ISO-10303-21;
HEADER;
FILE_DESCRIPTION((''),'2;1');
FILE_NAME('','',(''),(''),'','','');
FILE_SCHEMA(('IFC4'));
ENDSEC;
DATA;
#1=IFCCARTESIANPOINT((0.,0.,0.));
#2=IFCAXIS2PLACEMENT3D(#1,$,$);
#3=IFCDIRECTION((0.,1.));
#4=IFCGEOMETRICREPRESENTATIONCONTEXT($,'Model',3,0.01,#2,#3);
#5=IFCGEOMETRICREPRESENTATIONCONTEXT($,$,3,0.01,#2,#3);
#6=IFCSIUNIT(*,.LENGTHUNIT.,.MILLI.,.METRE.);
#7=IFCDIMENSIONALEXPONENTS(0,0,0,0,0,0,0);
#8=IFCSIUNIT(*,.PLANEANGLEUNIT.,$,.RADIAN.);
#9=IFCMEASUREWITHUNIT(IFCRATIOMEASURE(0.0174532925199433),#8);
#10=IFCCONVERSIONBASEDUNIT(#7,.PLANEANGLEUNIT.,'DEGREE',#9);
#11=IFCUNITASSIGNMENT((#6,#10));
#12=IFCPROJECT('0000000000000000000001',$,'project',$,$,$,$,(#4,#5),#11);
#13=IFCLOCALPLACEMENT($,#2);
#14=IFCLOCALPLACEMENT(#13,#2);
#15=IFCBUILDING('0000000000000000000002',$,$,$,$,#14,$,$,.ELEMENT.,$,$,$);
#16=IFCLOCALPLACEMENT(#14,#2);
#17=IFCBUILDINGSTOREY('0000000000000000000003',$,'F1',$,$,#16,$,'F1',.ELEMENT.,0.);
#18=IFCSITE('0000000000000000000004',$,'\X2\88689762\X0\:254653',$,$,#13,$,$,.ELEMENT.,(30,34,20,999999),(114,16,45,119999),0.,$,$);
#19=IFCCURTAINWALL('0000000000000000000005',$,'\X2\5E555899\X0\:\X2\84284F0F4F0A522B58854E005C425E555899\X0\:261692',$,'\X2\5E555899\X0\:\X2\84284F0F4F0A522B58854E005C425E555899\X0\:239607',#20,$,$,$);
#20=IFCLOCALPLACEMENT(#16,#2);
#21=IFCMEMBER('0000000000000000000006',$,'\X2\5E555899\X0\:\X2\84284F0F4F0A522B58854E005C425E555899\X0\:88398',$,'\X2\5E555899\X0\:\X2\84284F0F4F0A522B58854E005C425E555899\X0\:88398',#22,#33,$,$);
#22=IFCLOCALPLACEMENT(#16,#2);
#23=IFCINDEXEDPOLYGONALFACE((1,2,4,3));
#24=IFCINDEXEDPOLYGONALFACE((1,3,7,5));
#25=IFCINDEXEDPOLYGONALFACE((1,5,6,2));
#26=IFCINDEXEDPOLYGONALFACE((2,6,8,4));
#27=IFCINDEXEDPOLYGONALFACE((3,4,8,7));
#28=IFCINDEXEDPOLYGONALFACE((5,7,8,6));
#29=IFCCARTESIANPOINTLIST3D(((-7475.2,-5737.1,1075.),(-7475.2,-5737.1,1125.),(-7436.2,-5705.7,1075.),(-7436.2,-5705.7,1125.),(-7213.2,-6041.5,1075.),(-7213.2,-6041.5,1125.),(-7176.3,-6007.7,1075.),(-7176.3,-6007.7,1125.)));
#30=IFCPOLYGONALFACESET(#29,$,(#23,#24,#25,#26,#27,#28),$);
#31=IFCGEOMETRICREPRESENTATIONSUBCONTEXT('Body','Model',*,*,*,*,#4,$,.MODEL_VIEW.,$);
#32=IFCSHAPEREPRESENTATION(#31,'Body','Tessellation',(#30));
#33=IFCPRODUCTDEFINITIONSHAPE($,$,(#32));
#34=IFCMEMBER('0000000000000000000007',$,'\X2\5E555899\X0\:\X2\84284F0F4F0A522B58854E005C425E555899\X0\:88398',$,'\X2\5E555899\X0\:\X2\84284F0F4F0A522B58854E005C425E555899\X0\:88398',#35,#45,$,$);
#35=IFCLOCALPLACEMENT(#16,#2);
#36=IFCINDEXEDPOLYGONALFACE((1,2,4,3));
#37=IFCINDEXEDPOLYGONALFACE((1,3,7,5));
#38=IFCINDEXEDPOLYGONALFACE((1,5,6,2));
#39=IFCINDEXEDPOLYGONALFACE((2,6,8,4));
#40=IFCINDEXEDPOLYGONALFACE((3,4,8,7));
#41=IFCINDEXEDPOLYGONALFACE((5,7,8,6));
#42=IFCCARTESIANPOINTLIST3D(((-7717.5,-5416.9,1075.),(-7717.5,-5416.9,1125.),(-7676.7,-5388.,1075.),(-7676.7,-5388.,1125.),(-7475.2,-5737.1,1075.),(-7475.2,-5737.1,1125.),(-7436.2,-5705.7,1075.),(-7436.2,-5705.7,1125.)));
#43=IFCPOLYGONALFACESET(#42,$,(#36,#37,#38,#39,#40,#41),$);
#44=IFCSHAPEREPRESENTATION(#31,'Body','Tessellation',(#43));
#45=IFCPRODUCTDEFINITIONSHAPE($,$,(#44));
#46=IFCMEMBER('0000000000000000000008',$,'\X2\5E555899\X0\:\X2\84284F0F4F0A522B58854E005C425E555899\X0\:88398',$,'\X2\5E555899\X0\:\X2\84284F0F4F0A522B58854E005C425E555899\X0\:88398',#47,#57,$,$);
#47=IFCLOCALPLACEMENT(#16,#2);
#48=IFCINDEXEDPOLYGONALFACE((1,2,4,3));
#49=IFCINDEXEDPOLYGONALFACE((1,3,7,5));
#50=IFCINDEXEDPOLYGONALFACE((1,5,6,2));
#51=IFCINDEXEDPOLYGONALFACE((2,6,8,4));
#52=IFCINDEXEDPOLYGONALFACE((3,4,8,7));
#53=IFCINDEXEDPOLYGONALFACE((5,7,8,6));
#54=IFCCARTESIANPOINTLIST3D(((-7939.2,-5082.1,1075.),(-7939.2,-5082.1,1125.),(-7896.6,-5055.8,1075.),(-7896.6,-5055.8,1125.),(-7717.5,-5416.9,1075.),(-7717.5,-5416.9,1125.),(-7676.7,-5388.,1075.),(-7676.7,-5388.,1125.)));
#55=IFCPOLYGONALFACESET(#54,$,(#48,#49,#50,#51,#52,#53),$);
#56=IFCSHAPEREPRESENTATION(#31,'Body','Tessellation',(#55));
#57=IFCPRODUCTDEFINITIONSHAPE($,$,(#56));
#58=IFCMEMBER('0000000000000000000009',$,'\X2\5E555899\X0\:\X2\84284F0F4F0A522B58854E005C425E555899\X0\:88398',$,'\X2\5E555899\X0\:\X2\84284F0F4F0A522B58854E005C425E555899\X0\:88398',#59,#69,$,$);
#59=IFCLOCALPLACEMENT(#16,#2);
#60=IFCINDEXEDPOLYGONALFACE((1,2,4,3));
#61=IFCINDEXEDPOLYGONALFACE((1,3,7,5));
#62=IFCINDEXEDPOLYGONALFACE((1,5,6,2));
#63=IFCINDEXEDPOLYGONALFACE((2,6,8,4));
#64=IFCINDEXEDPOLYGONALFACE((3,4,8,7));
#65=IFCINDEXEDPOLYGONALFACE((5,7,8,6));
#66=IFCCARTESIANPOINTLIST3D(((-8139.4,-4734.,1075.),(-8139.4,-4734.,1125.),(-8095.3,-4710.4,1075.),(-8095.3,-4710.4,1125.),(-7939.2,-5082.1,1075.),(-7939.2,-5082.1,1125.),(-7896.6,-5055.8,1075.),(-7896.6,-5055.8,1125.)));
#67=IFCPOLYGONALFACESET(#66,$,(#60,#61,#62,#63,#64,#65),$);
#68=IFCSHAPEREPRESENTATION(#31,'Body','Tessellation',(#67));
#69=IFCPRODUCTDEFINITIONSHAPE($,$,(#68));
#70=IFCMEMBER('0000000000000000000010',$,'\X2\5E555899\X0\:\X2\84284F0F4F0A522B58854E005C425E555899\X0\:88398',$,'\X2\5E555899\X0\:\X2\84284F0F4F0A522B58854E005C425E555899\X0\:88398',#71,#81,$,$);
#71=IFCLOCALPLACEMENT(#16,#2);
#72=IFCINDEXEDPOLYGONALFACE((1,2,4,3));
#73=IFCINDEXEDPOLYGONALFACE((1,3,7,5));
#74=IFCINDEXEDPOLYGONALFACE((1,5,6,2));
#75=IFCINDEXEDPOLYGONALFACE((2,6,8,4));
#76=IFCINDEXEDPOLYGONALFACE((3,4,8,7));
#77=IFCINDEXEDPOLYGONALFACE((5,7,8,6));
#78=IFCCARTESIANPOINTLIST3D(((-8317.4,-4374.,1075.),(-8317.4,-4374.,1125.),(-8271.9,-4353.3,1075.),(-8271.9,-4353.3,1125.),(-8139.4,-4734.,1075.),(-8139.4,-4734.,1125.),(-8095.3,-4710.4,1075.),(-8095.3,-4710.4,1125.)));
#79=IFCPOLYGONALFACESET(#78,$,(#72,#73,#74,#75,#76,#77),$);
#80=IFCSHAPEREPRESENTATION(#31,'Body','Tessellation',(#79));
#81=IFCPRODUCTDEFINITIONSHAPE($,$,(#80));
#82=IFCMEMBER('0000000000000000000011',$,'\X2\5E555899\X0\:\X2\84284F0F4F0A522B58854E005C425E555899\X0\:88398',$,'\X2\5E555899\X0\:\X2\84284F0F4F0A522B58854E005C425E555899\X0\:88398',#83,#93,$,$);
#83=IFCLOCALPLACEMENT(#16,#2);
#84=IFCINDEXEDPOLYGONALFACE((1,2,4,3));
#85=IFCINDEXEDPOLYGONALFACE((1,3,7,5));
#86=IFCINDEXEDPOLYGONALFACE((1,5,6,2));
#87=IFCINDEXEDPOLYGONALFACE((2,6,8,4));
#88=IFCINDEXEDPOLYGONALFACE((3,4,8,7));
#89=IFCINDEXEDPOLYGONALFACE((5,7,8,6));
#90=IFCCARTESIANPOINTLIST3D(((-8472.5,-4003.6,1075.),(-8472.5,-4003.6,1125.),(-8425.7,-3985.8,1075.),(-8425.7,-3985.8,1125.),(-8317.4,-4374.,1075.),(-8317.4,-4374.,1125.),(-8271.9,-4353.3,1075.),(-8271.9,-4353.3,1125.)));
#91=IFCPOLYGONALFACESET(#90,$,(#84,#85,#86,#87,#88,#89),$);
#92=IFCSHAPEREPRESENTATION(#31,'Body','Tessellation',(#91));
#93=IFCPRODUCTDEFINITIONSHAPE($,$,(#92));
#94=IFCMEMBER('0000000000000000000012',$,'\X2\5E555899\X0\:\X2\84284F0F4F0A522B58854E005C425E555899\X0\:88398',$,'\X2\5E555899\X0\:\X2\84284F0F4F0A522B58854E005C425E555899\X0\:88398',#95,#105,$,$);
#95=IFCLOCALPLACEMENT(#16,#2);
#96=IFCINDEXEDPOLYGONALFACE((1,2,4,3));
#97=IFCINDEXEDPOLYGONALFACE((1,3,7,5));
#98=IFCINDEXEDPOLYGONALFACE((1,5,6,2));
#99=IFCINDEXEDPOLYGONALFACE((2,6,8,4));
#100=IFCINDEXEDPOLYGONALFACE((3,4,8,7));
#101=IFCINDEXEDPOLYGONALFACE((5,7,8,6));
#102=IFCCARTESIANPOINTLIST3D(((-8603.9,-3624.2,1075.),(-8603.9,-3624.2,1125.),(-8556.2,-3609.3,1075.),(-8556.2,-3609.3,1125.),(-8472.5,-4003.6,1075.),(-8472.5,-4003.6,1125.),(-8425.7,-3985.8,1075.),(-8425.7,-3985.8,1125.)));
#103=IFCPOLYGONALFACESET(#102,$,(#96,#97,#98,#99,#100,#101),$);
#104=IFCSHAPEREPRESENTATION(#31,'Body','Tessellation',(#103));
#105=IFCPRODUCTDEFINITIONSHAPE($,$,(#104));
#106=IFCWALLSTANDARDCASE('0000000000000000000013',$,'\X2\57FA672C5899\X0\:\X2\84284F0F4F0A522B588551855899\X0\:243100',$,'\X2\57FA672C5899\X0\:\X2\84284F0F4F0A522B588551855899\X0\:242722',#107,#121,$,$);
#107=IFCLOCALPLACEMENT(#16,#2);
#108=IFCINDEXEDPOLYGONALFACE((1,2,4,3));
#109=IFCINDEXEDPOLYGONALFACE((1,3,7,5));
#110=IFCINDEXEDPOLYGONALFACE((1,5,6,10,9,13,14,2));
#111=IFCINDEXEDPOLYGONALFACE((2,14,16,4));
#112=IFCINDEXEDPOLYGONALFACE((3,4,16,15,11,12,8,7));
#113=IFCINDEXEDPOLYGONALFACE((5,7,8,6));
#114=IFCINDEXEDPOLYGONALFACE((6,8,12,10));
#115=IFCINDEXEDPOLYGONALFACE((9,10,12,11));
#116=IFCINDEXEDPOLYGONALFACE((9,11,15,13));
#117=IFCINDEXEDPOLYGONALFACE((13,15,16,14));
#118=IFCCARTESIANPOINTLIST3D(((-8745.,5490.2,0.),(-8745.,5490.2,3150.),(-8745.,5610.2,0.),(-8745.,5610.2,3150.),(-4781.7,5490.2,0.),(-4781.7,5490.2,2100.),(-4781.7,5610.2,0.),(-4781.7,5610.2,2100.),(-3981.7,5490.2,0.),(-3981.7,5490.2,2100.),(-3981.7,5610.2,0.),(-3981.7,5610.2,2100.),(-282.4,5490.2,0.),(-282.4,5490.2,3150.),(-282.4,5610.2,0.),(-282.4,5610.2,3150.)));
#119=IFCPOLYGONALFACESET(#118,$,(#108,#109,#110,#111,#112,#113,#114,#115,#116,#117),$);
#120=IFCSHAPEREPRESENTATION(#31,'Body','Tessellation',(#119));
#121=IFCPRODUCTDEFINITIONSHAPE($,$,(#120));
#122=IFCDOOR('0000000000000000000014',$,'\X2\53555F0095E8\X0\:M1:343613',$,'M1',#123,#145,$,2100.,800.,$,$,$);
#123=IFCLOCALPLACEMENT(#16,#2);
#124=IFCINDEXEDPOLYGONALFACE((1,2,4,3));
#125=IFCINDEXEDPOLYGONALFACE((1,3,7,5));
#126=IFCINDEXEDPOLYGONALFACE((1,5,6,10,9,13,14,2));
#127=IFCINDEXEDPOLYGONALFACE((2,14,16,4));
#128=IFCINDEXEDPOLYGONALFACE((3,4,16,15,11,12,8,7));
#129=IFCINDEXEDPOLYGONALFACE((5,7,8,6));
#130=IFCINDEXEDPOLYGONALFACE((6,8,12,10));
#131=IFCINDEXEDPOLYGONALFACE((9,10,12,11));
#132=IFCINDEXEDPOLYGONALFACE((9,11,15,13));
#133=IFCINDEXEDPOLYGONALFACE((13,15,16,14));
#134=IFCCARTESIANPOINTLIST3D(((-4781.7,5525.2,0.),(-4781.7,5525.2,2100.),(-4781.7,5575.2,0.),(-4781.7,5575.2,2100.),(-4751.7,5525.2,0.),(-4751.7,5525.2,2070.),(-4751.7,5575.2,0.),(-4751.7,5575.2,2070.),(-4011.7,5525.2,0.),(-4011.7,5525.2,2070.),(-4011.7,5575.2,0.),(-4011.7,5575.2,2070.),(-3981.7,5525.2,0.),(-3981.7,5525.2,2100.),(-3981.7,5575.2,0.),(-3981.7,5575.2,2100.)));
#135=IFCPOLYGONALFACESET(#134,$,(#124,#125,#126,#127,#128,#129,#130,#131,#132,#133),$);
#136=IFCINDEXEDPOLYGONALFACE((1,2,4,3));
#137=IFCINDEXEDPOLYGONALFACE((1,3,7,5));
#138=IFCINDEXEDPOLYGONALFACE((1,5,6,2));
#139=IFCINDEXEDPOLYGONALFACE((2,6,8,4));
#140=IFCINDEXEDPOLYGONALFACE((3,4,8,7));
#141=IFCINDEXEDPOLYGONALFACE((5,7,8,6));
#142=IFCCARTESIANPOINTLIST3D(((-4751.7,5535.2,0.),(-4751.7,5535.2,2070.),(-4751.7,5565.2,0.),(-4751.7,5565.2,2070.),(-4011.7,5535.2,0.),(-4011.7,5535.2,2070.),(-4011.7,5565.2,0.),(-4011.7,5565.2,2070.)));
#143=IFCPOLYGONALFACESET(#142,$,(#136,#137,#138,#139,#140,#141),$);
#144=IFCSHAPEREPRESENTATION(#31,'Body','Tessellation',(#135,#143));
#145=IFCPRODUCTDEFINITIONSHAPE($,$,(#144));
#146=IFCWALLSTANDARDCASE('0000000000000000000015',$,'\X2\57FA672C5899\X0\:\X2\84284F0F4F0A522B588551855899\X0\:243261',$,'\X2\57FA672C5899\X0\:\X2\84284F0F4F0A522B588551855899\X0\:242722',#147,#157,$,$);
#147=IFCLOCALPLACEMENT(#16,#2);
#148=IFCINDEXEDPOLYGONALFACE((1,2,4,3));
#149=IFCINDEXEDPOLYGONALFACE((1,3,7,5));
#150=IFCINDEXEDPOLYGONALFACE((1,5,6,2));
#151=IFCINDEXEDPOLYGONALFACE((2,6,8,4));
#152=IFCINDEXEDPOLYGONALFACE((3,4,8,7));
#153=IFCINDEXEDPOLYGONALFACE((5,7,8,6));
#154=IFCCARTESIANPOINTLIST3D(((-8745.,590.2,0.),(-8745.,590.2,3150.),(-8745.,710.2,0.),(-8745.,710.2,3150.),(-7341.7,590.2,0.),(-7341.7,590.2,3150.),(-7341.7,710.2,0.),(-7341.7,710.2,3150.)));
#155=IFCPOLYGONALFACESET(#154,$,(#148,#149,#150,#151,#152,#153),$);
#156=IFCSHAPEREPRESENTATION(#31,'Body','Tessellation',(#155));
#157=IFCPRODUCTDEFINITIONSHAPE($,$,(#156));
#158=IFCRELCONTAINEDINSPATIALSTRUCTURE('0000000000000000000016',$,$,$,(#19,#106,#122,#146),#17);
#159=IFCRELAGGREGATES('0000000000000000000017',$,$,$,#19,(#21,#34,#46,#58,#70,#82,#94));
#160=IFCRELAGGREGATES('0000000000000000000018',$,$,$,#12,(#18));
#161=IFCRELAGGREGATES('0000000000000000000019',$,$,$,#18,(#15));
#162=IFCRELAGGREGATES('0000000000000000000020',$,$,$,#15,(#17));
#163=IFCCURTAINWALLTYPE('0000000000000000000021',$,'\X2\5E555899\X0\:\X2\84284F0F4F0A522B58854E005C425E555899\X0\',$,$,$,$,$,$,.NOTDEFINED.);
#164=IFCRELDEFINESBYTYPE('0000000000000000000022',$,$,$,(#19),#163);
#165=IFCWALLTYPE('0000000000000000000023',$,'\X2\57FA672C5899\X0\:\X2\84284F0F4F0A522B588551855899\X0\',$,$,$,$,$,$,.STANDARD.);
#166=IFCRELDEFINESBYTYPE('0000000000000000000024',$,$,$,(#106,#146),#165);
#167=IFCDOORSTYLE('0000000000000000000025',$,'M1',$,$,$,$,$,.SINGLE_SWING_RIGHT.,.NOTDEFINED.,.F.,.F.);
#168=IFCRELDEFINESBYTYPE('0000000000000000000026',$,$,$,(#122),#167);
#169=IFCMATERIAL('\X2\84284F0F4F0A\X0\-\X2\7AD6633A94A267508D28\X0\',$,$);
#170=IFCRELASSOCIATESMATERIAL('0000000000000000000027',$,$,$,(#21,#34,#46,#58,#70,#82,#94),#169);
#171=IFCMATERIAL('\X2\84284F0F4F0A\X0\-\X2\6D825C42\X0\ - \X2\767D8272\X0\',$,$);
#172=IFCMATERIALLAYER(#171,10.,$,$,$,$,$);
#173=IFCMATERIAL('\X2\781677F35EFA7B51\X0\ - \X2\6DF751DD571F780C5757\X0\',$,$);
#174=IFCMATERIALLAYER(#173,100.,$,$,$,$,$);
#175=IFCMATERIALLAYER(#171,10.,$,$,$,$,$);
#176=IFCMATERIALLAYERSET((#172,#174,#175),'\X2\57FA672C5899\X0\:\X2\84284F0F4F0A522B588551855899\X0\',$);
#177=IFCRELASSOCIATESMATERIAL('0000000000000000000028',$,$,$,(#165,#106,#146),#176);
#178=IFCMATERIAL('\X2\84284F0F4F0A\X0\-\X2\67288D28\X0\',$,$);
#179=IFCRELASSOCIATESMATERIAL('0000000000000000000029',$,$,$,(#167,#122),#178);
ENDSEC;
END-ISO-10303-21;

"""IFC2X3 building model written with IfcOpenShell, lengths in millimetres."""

from ifc_helpers import new_model, entity, si_unit, converted_unit, direction, frame, frame_2d, origin, origin_2d_with_axis, place, context, subcontext, project, spatial, polyline, rectangle, outline, extrude, clip, halfspace, bounded_halfspace, source, transform, mapped, material, layer, layer_set, layer_usage, type_object, type_shapes, element, fill, aggregate, save


model = new_model("IFC2X3")

# Units and contexts
model_context = context("Model", 3, precision=0.01, world=origin(), true_north=direction((0.0, 1.0)))
context_of_model = context(None, 3, precision=0.01, world=origin(), true_north=direction((0.0, 1.0)))
body_context = subcontext(model_context, "Body", "Model", "MODEL_VIEW")
ifc_project = project(units=[si_unit("LENGTHUNIT", "METRE", prefix="MILLI"), converted_unit("PLANEANGLEUNIT", "DEGREE", entity("IfcRatioMeasure", 0.0174532925199433), si_unit("PLANEANGLEUNIT", "RADIAN"), dimensions=[0, 0, 0, 0, 0, 0, 0])], contexts=[model_context, context_of_model])

# Site, building, storey
site_placement = place(None, origin())
site = spatial("IfcSite", under=ifc_project, at=site_placement, Name="表面:254653", CompositionType="ELEMENT", RefLatitude=(30, 34, 20, 999999), RefLongitude=(114, 16, 45, 119999), RefElevation=0.0)
building_placement = place(site_placement, origin())
building = spatial("IfcBuilding", under=site, at=building_placement, CompositionType="ELEMENT")
storey_placement = place(building_placement, origin())
storey = spatial("IfcBuildingStorey", under=building, at=storey_placement, Name="F1", LongName="F1", CompositionType="ELEMENT", Elevation=0.0)

# Curtain wall, members
curtain_wall_type = type_object("IfcCurtainWallType", Name="幕墙:萨伏伊别墅一层幕墙", PredefinedType="NOTDEFINED")
curtain_wall_placement = place(storey_placement, origin())
curtain_wall = element("IfcCurtainWall", 1, at=curtain_wall_placement, inside=storey, type_object=curtain_wall_type, Name="幕墙:萨伏伊别墅一层幕墙:261692", ObjectType="幕墙:萨伏伊别墅一层幕墙:239607")
ifc_material_1 = material(Name="萨伏伊-竖挺钢材质")
member_1_placement = place(curtain_wall_placement, origin())
member_1 = element("IfcMember", 2, at=member_1_placement, material=ifc_material_1, Name="幕墙:萨伏伊别墅一层幕墙:88398", ObjectType="幕墙:萨伏伊别墅一层幕墙:88398", context=body_context, shape_type="Clipping", body=[
    clip(clip(extrude(rectangle(XDim=50.0, YDim=50.0, at=frame_2d((0.0, 0.0), x_axis=(1.0, 0.0))), frame((-7456.2, -5720.8, 1100.0), z_axis=(0.652297, -0.757964, 0.0), x_axis=(0.0, 0.0, -1.0)), (0.0, 0.0, 1.0), 401.6), halfspace(frame((-7455.7, -5721.4, 795.2), z_axis=(-0.62816, 0.778084, 0.0), x_axis=(0.778084, 0.62816, 0.0)), False)), halfspace(frame((-7194.8, -6024.6, 795.2), z_axis=(0.675789, -0.737095, 0.0), x_axis=(0.737095, 0.675789, 0.0)), False)),
])
member_2_placement = place(curtain_wall_placement, origin())
member_2 = element("IfcMember", 3, at=member_2_placement, material=ifc_material_1, Name="幕墙:萨伏伊别墅一层幕墙:88398", ObjectType="幕墙:萨伏伊别墅一层幕墙:88398", context=body_context, shape_type="Clipping", body=[
    clip(clip(extrude(rectangle(XDim=50.0, YDim=50.0, at=frame_2d((0.0, 0.0), x_axis=(1.0, 0.0))), frame((-7697.5, -5401.8, 1100.0), z_axis=(0.603404, -0.797436, 0.0), x_axis=(0.0, 0.0, -1.0)), (0.0, 0.0, 1.0), 401.6), halfspace(frame((-7697.1, -5402.5, 795.2), z_axis=(-0.578051, 0.816001, 0.0), x_axis=(0.816001, 0.578051, 0.0)), False)), halfspace(frame((-7455.7, -5721.4, 795.2), z_axis=(0.62816, -0.778084, 0.0), x_axis=(0.778084, 0.62816, 0.0)), False)),
])
member_3_placement = place(curtain_wall_placement, origin())
member_3 = element("IfcMember", 4, at=member_3_placement, material=ifc_material_1, Name="幕墙:萨伏伊别墅一层幕墙:88398", ObjectType="幕墙:萨伏伊别墅一层幕墙:88398", context=body_context, shape_type="Clipping", body=[
    clip(clip(extrude(rectangle(XDim=50.0, YDim=50.0, at=frame_2d((0.0, 0.0), x_axis=(1.0, 0.0))), frame((-7918.3, -5068.3, 1100.0), z_axis=(0.552128, -0.83376, 0.0), x_axis=(0.0, 0.0, -1.0)), (0.0, 0.0, 1.0), 401.6), halfspace(frame((-7917.9, -5068.9, 795.2), z_axis=(-0.525659, 0.850695, 0.0), x_axis=(0.850695, 0.525659, 0.0)), False)), halfspace(frame((-7697.1, -5402.5, 795.2), z_axis=(0.578051, -0.816001, 0.0), x_axis=(0.816001, 0.578051, 0.0)), False)),
])
member_4_placement = place(curtain_wall_placement, origin())
member_4 = element("IfcMember", 5, at=member_4_placement, material=ifc_material_1, Name="幕墙:萨伏伊别墅一层幕墙:88398", ObjectType="幕墙:萨伏伊别墅一层幕墙:88398", context=body_context, shape_type="Clipping", body=[
    clip(clip(extrude(rectangle(XDim=50.0, YDim=50.0, at=frame_2d((0.0, 0.0), x_axis=(1.0, 0.0))), frame((-8117.8, -4721.5, 1100.0), z_axis=(0.498671, -0.866791, 0.0), x_axis=(0.0, 0.0, -1.0)), (0.0, 0.0, 1.0), 401.6), halfspace(frame((-8117.4, -4722.2, 795.2), z_axis=(-0.471192, 0.882031, 0.0), x_axis=(0.882031, 0.471192, 0.0)), False)), halfspace(frame((-7917.9, -5068.9, 795.2), z_axis=(0.525659, -0.850695, 0.0), x_axis=(0.850695, 0.525659, 0.0)), False)),
])
member_5_placement = place(curtain_wall_placement, origin())
member_5 = element("IfcMember", 6, at=member_5_placement, material=ifc_material_1, Name="幕墙:萨伏伊别墅一层幕墙:88398", ObjectType="幕墙:萨伏伊别墅一层幕墙:88398", context=body_context, shape_type="Clipping", body=[
    clip(clip(extrude(rectangle(XDim=50.0, YDim=50.0, at=frame_2d((0.0, 0.0), x_axis=(1.0, 0.0))), frame((-8295.0, -4363.0, 1100.0), z_axis=(0.443246, -0.8964, 0.0), x_axis=(0.0, 0.0, -1.0)), (0.0, 0.0, 1.0), 401.6), halfspace(frame((-8294.7, -4363.7, 795.2), z_axis=(-0.414863, 0.909884, 0.0), x_axis=(0.909884, 0.414863, 0.0)), False)), halfspace(frame((-8117.4, -4722.2, 795.2), z_axis=(0.471192, -0.882031, 0.0), x_axis=(0.882031, 0.471192, 0.0)), False)),
])
member_6_placement = place(curtain_wall_placement, origin())
member_6 = element("IfcMember", 7, at=member_6_placement, material=ifc_material_1, Name="幕墙:萨伏伊别墅一层幕墙:88398", ObjectType="幕墙:萨伏伊别墅一层幕墙:88398", context=body_context, shape_type="Clipping", body=[
    clip(clip(extrude(rectangle(XDim=50.0, YDim=50.0, at=origin_2d_with_axis()), frame((-8449.4, -3994.0, 1100.0), z_axis=(0.386071, -0.922469, 0.0), x_axis=(0.0, 0.0, -1.0)), (0.0, 0.0, 1.0), 401.6), halfspace(frame((-8449.1, -3994.7, 795.2), z_axis=(-0.356897, 0.934144, 0.0), x_axis=(0.934144, 0.356897, 0.0)), False)), halfspace(frame((-8294.7, -4363.7, 795.2), z_axis=(0.414863, -0.909884, 0.0), x_axis=(0.909884, 0.414863, 0.0)), False)),
])
member_7_placement = place(curtain_wall_placement, origin())
member_7 = element("IfcMember", 8, at=member_7_placement, material=ifc_material_1, Name="幕墙:萨伏伊别墅一层幕墙:88398", ObjectType="幕墙:萨伏伊别墅一层幕墙:88398", context=body_context, shape_type="Clipping", body=[
    clip(clip(extrude(rectangle(XDim=50.0, YDim=50.0, at=frame_2d((0.0, 0.0), x_axis=(1.0, 0.0))), frame((-8580.3, -3616.0, 1100.0), z_axis=(0.327371, -0.944896, 0.0), x_axis=(0.0, 0.0, -1.0)), (0.0, 0.0, 1.0), 401.6), halfspace(frame((-8580.1, -3616.7, 795.2), z_axis=(-0.297522, 0.954715, 0.0), x_axis=(0.954715, 0.297522, 0.0)), False)), halfspace(frame((-8449.1, -3994.7, 795.2), z_axis=(0.356897, -0.934144, 0.0), x_axis=(0.934144, 0.356897, 0.0)), False)),
])
aggregate(curtain_wall, [member_1, member_2, member_3, member_4, member_5, member_6, member_7])

# Wall, opening, door
ifc_material_2 = material(Name="萨伏伊-涂层 - 白色")
ifc_layer_1 = layer(ifc_material_2, 10.0)
ifc_material_3 = material(Name="砖石建筑 - 混凝土砌块")
ifc_layer_2 = layer(ifc_material_3, 100.0)
ifc_layer_3 = layer(ifc_material_2, 10.0)
ifc_layer_set = layer_set([ifc_layer_1, ifc_layer_2, ifc_layer_3], Name="基本墙:萨伏伊别墅内墙")
ifc_layer_usage_1 = layer_usage(ifc_layer_set, "AXIS2", "NEGATIVE", 60.0)
wall_type = type_object("IfcWallType", Name="基本墙:萨伏伊别墅内墙", PredefinedType="STANDARD", material=ifc_layer_set)
wall_1_placement = place(storey_placement, frame((-282.4, 5550.2, 0.0), z_axis=(0.0, 0.0, 1.0), x_axis=(-1.0, 0.0, 0.0)))
wall_1 = element("IfcWallStandardCase", 9, at=wall_1_placement, inside=storey, type_object=wall_type, material=ifc_layer_usage_1, Name="基本墙:萨伏伊别墅内墙:243100", ObjectType="基本墙:萨伏伊别墅内墙:242722", context=body_context, shape_type="Clipping", body=[
    clip(extrude(rectangle(XDim=8462.6, YDim=120.0, at=frame_2d((4231.3, 0.0), x_axis=(-1.0, 0.0))), origin(), (0.0, 0.0, 1.0), 3150.0), bounded_halfspace(frame((0.0, -60.0, 3150.0), z_axis=(0.0, 0.0, -1.0), x_axis=(0.0, 1.0, 0.0)), True, frame((0.0, -60.0, 3150.0)), polyline([(0.0, 0.0), (139.3, 0.0), (259.3, 0.0), (3439.3, 0.0), (3559.3, 0.0), (8462.6, 0.0), (8462.6, 120.0), (4759.3, 120.0), (4639.3, 120.0), (1119.3, 120.0), (999.3, 120.0), (0.0, 120.0), (0.0, 0.0)]))),
])
opening_placement = place(wall_1_placement, frame((4499.3, 60.0, 0.0)))
opening = element("IfcOpeningElement", 10, at=opening_placement, cuts=wall_1, ObjectType="Opening", context=body_context, shape_type="SweptSolid", body=[
    extrude(rectangle(XDim=2100.0, YDim=800.0, at=frame_2d((1050.0, 400.0), x_axis=(1.0, 0.0))), frame((0.0, 0.0, 0.0), z_axis=(0.0, -1.0, 0.0), x_axis=(0.0, 0.0, 1.0)), (0.0, 0.0, 1.0), 120.0),
])
ifc_material_4 = material(Name="萨伏伊-木质")
door_style = type_object("IfcDoorStyle", Name="M1", ConstructionType="NOTDEFINED", OperationType="SINGLE_SWING_RIGHT", ParameterTakesPrecedence=False, Sizeable=False, material=ifc_material_4)
shared_shape_1 = source(origin(), body_context, "Body", "SweptSolid", [
    extrude(outline(polyline([(-1057.5, -400.0), (1042.5, -400.0), (1042.5, -370.0), (-1027.5, -370.0), (-1027.5, 370.0), (1042.5, 370.0), (1042.5, 400.0), (-1057.5, 400.0), (-1057.5, -400.0)])), frame((400.0, 85.0, 1042.5), z_axis=(0.0, -1.0, 0.0), x_axis=(0.0, 0.0, -1.0)), (0.0, 0.0, 1.0), 50.0),
    extrude(rectangle(XDim=740.0, YDim=30.0, at=origin_2d_with_axis()), frame((400.0, 60.0, 0.0)), (0.0, 0.0, 1.0), 2070.0),
])
type_shapes(door_style, [shared_shape_1])
door_placement = place(opening_placement, frame((0.0, 0.0, 0.0), z_axis=(0.0, 0.0, 1.0), x_axis=(-1.0, 0.0, 0.0)))
door = element("IfcDoor", 11, at=door_placement, inside=storey, type_object=door_style, material=ifc_material_4, Name="单开门:M1:343613", ObjectType="M1", OverallHeight=2100.0, OverallWidth=800.0, context=body_context, shape_type="MappedRepresentation", body=[
    mapped(shared_shape_1, transform((0.0, 0.0, 0.0), scale=1.0)),
])
fill(opening, door)

# Wall
ifc_layer_usage_2 = layer_usage(ifc_layer_set, "AXIS2", "NEGATIVE", 60.0)
wall_2_placement = place(storey_placement, frame((-7341.7, 650.2, 0.0), z_axis=(0.0, 0.0, 1.0), x_axis=(-1.0, 0.0, 0.0)))
element("IfcWallStandardCase", 12, at=wall_2_placement, inside=storey, type_object=wall_type, material=ifc_layer_usage_2, Name="基本墙:萨伏伊别墅内墙:243261", ObjectType="基本墙:萨伏伊别墅内墙:242722", context=body_context, shape_type="Clipping", body=[
    clip(extrude(rectangle(XDim=1403.3, YDim=120.0, at=frame_2d((701.7, 0.0), x_axis=(-1.0, 0.0))), origin(), (0.0, 0.0, 1.0), 3150.0), bounded_halfspace(frame((0.0, -60.0, 3150.0), z_axis=(0.0, 0.0, -1.0), x_axis=(0.0, 1.0, 0.0)), True, frame((0.0, -60.0, 3150.0)), polyline([(0.0, 0.0), (1403.3, 0.0), (1403.3, 120.0), (0.0, 120.0), (0.0, 0.0)]))),
])

save(model, "model.ifc")
